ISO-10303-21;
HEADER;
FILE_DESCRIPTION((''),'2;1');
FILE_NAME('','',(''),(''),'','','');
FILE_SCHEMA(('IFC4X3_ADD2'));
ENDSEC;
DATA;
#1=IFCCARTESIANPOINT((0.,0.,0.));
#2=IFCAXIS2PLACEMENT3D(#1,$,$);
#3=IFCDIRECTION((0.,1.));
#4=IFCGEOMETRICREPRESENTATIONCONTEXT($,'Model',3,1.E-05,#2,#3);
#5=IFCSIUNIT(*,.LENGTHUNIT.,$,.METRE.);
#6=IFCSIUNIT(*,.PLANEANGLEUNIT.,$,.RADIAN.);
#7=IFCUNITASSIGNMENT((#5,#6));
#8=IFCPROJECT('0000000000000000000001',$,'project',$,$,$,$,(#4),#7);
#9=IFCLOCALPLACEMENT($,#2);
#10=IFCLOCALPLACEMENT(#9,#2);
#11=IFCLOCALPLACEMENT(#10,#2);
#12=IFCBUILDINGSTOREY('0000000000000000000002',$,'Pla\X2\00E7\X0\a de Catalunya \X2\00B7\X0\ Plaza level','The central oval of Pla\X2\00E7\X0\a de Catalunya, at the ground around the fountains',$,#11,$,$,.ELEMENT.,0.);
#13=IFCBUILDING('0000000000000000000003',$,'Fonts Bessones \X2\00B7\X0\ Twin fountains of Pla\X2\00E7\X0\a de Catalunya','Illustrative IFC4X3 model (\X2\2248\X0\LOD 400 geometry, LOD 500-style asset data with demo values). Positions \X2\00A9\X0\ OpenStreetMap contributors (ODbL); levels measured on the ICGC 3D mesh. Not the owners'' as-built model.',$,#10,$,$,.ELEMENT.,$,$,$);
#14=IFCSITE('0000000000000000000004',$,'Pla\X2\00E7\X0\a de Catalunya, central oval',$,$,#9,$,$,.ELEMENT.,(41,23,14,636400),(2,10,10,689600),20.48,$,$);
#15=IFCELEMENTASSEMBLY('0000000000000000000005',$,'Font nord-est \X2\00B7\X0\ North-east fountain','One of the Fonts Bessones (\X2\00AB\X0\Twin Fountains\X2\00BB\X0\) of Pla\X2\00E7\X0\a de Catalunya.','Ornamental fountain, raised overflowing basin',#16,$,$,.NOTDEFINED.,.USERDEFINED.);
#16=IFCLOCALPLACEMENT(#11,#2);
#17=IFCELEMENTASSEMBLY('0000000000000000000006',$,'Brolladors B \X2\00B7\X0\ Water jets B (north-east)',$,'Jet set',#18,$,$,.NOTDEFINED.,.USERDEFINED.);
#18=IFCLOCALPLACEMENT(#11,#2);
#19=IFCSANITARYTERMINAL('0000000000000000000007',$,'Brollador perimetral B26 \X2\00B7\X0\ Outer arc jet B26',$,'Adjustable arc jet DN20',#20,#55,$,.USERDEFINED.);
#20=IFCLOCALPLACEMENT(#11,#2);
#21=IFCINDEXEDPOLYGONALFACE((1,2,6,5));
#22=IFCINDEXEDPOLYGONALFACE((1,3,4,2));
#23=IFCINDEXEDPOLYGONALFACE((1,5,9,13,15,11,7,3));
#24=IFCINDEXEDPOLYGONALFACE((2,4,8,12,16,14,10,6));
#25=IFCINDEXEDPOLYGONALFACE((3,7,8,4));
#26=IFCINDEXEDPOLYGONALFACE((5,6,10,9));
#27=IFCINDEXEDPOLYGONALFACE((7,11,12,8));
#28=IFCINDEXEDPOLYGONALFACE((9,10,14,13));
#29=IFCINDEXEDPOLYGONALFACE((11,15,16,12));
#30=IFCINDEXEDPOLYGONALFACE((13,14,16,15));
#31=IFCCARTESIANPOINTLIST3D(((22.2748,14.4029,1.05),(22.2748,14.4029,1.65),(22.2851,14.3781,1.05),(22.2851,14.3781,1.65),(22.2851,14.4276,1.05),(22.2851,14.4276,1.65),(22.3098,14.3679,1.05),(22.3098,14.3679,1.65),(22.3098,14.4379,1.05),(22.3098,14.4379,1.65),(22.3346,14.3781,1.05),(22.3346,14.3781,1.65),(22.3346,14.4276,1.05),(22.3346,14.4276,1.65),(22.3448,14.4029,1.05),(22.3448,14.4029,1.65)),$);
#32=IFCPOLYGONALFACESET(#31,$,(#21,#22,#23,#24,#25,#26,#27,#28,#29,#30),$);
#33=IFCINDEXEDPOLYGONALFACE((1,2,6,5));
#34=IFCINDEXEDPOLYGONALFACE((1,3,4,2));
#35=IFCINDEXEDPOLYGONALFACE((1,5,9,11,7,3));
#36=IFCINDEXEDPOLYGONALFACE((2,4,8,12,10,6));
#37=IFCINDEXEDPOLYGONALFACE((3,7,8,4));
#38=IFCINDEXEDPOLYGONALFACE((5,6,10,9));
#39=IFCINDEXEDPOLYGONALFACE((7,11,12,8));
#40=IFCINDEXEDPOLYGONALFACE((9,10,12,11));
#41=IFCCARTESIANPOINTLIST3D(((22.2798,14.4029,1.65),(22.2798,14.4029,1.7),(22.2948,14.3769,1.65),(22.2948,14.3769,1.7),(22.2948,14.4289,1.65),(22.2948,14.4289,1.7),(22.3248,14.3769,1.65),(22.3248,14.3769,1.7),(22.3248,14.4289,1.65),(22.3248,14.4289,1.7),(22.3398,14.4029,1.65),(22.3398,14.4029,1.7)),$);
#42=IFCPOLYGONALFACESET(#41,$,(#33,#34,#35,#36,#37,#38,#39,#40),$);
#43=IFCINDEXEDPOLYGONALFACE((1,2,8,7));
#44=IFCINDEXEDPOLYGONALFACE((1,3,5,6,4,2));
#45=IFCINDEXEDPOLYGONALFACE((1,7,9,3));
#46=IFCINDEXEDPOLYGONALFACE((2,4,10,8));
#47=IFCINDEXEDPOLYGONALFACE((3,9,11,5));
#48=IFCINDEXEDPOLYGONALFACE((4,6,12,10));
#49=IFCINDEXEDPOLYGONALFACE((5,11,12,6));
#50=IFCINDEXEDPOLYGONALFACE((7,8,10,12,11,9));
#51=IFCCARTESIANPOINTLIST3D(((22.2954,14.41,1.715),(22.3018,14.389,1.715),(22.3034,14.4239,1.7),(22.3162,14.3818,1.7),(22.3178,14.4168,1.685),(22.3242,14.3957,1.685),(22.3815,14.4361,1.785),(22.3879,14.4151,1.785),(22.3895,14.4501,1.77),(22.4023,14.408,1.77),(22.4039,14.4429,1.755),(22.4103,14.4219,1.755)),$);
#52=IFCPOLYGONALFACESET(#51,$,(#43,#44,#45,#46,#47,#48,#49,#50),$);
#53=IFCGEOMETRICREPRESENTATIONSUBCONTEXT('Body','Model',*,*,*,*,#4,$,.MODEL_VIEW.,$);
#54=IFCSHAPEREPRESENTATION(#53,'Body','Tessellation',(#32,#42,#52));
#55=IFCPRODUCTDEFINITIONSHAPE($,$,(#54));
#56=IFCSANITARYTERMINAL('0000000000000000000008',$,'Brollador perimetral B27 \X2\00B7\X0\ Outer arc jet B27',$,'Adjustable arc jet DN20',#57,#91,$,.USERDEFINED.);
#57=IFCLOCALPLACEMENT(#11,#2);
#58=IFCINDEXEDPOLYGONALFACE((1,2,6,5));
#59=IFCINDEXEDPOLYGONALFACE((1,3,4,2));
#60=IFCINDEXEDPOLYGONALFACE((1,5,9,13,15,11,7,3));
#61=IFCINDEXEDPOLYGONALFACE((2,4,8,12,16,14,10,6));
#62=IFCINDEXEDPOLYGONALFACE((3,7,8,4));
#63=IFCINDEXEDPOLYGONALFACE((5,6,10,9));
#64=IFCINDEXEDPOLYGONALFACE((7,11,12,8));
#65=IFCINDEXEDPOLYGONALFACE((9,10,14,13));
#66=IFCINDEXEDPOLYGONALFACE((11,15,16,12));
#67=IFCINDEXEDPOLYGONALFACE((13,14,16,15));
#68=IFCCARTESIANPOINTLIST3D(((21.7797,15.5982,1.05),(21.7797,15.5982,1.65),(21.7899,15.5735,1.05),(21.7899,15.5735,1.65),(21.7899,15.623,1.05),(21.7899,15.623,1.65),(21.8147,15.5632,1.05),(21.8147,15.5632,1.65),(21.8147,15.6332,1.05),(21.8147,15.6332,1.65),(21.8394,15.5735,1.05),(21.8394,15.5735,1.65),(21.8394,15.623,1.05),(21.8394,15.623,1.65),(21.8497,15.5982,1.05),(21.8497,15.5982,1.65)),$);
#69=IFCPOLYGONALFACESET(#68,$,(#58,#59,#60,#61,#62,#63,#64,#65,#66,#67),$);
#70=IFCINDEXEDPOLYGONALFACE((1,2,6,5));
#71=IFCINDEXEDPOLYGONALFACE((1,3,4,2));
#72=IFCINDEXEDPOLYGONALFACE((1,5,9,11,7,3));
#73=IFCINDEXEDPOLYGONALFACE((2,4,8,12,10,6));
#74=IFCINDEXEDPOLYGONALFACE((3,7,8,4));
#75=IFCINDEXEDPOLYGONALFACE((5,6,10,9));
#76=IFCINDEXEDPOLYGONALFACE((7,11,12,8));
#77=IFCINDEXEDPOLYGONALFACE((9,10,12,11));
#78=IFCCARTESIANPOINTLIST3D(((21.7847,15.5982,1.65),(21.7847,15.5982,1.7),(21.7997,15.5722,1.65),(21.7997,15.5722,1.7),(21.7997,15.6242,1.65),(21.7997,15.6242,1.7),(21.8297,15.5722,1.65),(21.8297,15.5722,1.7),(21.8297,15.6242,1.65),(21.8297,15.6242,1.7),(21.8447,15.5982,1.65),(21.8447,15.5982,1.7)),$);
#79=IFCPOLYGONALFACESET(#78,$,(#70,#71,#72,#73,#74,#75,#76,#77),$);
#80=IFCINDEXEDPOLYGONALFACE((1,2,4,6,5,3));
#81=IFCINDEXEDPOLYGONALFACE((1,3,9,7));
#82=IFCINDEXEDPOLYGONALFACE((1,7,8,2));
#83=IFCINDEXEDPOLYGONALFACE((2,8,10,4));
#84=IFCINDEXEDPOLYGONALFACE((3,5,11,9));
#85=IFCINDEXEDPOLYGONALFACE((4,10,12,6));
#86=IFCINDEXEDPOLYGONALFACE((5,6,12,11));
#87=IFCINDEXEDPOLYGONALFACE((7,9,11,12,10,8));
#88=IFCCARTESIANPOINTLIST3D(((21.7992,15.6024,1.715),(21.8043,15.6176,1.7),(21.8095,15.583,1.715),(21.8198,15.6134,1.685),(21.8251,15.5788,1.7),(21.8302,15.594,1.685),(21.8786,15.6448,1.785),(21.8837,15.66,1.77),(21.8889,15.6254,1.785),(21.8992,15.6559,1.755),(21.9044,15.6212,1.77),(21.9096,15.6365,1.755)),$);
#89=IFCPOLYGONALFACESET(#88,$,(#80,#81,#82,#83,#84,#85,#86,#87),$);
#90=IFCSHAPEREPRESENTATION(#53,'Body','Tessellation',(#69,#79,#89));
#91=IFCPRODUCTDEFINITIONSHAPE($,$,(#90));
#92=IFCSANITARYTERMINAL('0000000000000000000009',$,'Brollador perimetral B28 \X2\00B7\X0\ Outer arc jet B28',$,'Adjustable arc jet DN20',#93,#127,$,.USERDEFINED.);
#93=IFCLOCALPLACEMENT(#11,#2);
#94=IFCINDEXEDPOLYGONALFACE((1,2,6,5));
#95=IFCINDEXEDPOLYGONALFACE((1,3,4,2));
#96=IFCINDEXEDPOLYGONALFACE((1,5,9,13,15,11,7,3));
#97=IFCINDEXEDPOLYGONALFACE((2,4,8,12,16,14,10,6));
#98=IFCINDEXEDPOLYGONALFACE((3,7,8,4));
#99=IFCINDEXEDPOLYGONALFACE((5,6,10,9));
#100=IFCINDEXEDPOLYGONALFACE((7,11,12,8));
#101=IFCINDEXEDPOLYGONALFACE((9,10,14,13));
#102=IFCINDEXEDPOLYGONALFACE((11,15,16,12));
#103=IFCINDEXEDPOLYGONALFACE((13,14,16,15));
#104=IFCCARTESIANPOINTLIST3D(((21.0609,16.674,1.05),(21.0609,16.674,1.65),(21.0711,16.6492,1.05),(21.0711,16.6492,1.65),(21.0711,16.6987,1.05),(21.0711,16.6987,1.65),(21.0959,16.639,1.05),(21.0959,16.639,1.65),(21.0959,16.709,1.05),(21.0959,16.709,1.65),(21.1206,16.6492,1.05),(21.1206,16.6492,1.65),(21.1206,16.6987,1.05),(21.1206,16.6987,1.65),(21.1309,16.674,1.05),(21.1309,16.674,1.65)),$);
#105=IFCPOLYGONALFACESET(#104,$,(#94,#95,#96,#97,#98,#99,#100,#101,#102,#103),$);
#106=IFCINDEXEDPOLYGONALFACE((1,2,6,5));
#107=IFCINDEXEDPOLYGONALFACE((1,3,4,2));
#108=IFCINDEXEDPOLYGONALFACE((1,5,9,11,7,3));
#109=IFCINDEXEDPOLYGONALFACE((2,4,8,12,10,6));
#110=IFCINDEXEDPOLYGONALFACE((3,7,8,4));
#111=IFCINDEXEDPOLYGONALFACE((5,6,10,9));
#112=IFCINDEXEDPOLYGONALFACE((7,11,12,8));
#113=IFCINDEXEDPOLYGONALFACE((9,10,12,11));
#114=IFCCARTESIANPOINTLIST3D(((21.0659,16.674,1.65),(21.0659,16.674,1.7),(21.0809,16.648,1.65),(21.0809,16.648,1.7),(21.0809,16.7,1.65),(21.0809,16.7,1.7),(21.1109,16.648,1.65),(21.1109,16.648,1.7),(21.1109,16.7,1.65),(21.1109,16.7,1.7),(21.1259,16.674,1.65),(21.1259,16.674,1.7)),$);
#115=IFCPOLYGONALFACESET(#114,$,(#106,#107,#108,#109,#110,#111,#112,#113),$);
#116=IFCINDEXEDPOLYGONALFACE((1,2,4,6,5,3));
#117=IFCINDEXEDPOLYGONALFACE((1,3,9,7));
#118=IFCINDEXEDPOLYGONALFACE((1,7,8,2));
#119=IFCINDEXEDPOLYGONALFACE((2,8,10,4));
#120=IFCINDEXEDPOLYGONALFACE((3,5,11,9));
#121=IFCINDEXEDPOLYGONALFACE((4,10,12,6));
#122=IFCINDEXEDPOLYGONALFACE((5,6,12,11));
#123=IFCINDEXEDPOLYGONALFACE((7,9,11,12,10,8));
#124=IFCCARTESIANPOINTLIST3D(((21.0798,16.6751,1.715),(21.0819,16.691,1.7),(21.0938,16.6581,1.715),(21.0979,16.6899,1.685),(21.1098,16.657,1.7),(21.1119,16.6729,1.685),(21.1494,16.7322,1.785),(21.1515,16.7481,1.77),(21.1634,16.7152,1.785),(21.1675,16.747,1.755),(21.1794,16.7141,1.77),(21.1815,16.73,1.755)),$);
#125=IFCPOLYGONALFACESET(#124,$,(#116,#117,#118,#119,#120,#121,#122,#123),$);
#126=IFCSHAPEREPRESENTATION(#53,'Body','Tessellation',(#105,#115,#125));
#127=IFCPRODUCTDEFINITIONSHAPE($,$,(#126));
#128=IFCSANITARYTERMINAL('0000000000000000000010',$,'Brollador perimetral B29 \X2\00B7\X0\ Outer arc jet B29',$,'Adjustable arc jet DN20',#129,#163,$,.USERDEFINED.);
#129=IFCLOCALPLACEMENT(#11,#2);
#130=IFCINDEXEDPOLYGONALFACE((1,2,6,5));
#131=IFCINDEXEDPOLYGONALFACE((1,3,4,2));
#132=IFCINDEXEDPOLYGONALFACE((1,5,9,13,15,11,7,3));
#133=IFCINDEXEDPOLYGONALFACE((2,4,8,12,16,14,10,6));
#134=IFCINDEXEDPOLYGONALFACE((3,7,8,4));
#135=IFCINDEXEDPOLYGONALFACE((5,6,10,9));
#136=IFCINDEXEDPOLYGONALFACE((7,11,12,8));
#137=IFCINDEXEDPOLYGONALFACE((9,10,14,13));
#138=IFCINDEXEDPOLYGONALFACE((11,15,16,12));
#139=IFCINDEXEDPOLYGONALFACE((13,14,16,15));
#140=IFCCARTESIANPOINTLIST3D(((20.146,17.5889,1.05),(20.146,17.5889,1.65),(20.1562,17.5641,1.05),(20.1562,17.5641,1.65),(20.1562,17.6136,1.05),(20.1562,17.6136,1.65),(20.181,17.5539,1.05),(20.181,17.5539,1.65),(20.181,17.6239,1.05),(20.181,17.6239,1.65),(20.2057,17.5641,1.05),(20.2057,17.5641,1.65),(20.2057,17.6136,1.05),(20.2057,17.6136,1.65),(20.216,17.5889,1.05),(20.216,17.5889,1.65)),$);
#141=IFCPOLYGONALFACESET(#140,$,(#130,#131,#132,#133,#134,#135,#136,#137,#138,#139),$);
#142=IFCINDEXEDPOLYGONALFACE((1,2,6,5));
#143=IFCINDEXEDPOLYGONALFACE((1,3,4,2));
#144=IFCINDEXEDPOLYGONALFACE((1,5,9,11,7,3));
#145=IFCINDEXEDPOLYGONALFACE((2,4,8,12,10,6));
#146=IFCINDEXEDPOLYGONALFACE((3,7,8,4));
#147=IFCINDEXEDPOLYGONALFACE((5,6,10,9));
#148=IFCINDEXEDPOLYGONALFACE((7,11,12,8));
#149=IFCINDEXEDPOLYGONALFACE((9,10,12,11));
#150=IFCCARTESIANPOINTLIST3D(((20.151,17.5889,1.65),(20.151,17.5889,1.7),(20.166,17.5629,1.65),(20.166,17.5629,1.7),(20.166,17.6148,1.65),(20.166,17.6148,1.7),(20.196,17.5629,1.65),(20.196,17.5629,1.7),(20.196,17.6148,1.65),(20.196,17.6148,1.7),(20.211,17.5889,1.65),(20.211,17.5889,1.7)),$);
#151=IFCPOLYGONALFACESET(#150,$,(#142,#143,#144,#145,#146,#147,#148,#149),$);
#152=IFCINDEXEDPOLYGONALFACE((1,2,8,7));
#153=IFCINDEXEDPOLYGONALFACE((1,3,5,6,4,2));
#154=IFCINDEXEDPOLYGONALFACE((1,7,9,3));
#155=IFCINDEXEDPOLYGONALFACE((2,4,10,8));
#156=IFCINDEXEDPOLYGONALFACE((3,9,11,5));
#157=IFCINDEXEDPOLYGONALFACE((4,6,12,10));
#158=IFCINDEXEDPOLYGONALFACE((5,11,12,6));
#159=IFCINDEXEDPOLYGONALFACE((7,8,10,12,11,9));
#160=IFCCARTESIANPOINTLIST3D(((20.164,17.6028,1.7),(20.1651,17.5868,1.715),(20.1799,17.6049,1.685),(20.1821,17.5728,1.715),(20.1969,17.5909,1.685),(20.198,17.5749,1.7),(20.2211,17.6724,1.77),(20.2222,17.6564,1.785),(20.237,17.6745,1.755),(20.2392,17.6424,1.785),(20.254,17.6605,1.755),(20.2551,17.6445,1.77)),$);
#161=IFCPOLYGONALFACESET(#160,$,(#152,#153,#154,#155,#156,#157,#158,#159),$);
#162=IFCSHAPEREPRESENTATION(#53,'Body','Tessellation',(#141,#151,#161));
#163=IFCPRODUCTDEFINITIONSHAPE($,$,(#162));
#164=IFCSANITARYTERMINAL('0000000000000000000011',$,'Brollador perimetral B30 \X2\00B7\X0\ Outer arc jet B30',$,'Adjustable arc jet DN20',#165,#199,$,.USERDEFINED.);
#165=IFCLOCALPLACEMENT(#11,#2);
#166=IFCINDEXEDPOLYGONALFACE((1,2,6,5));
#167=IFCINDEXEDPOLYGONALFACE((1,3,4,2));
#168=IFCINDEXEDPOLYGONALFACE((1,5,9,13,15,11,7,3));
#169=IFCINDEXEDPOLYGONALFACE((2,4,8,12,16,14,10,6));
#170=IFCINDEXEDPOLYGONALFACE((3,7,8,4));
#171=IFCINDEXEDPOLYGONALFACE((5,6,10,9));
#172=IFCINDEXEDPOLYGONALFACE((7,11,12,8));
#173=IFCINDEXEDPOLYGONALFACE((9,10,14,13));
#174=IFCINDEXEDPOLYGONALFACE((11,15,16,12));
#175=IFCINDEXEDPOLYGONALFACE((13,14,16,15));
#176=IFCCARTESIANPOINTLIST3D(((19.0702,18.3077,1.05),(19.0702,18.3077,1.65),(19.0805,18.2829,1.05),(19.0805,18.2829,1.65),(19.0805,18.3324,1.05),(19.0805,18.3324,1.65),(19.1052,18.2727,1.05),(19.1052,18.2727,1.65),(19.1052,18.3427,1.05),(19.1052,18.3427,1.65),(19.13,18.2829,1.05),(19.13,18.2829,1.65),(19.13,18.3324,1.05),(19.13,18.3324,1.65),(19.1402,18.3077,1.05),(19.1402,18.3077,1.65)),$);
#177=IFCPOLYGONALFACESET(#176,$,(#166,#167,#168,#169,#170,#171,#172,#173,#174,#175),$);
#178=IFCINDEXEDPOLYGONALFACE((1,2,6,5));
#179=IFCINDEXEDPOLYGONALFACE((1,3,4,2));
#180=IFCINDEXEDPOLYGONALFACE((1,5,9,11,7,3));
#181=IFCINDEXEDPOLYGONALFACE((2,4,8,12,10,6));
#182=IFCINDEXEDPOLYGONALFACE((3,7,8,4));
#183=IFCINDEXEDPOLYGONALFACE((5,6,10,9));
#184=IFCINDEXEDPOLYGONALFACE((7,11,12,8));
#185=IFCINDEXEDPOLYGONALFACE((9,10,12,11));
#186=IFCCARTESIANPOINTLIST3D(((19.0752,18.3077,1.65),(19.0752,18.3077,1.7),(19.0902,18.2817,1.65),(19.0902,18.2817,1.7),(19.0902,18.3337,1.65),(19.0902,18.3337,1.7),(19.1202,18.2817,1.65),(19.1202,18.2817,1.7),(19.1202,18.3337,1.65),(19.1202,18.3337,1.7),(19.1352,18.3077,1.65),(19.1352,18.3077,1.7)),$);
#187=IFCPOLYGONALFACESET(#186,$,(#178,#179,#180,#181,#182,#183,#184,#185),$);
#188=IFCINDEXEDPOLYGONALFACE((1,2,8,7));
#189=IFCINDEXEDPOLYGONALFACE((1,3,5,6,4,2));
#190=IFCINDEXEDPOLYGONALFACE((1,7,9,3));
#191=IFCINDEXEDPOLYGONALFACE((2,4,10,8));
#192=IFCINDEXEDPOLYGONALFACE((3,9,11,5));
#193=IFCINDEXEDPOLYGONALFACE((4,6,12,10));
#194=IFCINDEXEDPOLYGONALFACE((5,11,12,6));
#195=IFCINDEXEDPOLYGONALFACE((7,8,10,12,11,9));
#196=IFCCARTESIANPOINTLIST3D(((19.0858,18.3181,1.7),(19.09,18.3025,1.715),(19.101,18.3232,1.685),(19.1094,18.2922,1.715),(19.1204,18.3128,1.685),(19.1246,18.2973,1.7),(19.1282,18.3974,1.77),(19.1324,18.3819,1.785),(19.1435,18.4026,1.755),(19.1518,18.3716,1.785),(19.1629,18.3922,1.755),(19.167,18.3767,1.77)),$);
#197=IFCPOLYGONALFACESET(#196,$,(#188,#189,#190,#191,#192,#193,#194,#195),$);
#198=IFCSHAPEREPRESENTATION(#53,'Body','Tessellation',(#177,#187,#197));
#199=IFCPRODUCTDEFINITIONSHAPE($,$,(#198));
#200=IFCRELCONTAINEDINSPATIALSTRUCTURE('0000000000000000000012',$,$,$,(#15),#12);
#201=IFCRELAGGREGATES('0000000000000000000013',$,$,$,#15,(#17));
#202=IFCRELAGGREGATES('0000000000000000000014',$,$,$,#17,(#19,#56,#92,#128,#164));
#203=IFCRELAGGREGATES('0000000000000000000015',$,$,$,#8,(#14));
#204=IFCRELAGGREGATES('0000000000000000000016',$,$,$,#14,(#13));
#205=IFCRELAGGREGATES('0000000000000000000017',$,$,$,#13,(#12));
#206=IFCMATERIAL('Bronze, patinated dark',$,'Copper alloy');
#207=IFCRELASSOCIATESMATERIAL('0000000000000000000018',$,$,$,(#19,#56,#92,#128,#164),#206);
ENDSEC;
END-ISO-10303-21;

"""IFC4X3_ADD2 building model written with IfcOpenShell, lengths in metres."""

from ifc_helpers import new_model, si_unit, direction, frame, origin, place, context, subcontext, project, spatial, polyline, outline, extrude, material, element, aggregate, save


model = new_model("IFC4X3_ADD2")

# Units and contexts
model_context = context("Model", 3, precision=1e-05, world=origin(), true_north=direction((0.0, 1.0)))
body_context = subcontext(model_context, "Body", "Model", "MODEL_VIEW")
ifc_project = project(units=[si_unit("LENGTHUNIT", "METRE"), si_unit("PLANEANGLEUNIT", "RADIAN")], contexts=[model_context])

# Site, building, storey
site_placement = place(None, origin())
site = spatial("IfcSite", under=ifc_project, at=site_placement, Name="Plaça de Catalunya, central oval", CompositionType="ELEMENT", RefLatitude=(41, 23, 14, 636400), RefLongitude=(2, 10, 10, 689600), RefElevation=20.48)
building_placement = place(site_placement, origin())
building = spatial("IfcBuilding", under=site, at=building_placement, Name="Fonts Bessones · Twin fountains of Plaça de Catalunya", Description="Illustrative IFC4X3 model (≈LOD 400 geometry, LOD 500-style asset data with demo values). Positions © OpenStreetMap contributors (ODbL); levels measured on the ICGC 3D mesh. Not the owners' as-built model.", CompositionType="ELEMENT")
storey_placement = place(building_placement, origin())
storey = spatial("IfcBuildingStorey", under=building, at=storey_placement, Name="Plaça de Catalunya · Plaza level", Description="The central oval of Plaça de Catalunya, at the ground around the fountains", CompositionType="ELEMENT", Elevation=0.0)

# Element assemblies, sanitary terminals
assembly_1_placement = place(building_placement, origin())
assembly_1 = element("IfcElementAssembly", 1, at=assembly_1_placement, inside=storey, Name="Font nord-est · North-east fountain", Description="One of the Fonts Bessones («Twin Fountains») of Plaça de Catalunya.", ObjectType="Ornamental fountain, raised overflowing basin", AssemblyPlace="NOTDEFINED", PredefinedType="USERDEFINED")
assembly_2_placement = place(building_placement, origin())
assembly_2 = element("IfcElementAssembly", 2, at=assembly_2_placement, Name="Brolladors B · Water jets B (north-east)", ObjectType="Jet set", AssemblyPlace="NOTDEFINED", PredefinedType="USERDEFINED")
aggregate(assembly_1, [assembly_2])
ifc_material_1 = material(Name="Bronze, patinated dark", Category="Copper alloy")
sanitary_terminal_1_placement = place(building_placement, origin())
sanitary_terminal_1 = element("IfcSanitaryTerminal", 3, at=sanitary_terminal_1_placement, material=ifc_material_1, Name="Brollador perimetral B26 · Outer arc jet B26", ObjectType="Adjustable arc jet DN20", PredefinedType="USERDEFINED", context=body_context, shape_type="SweptSolid", body=[
    extrude(outline(polyline([(22.3448, 14.4029), (22.3346, 14.4276), (22.3098, 14.4379), (22.2851, 14.4276), (22.2748, 14.4029), (22.2851, 14.3781), (22.3098, 14.3679), (22.3346, 14.3781), (22.3448, 14.4029)])), frame((0.0, 0.0, 1.05)), (0.0, 0.0, 1.0), 0.6),
    extrude(outline(polyline([(22.3398, 14.4029), (22.3248, 14.4289), (22.2948, 14.4289), (22.2798, 14.4029), (22.2948, 14.3769), (22.3248, 14.3769), (22.3398, 14.4029)])), frame((0.0, 0.0, 1.65)), (0.0, 0.0, 1.0), 0.05),
    extrude(outline(polyline([(0.022, 0.0), (0.011, 0.0191), (-0.011, 0.0191), (-0.022, 0.0), (-0.011, -0.0191), (0.011, -0.0191), (0.022, 0.0)])), frame((22.3098, 14.4029, 1.7), z_axis=(0.755363, 0.229137, 0.613941), x_axis=(0.290285, -0.95694, 0.0)), (0.0, 0.0, 1.0), 0.114),
])
sanitary_terminal_2_placement = place(building_placement, origin())
sanitary_terminal_2 = element("IfcSanitaryTerminal", 4, at=sanitary_terminal_2_placement, material=ifc_material_1, Name="Brollador perimetral B27 · Outer arc jet B27", ObjectType="Adjustable arc jet DN20", PredefinedType="USERDEFINED", context=body_context, shape_type="SweptSolid", body=[
    extrude(outline(polyline([(21.8497, 15.5982), (21.8394, 15.623), (21.8147, 15.6332), (21.7899, 15.623), (21.7797, 15.5982), (21.7899, 15.5735), (21.8147, 15.5632), (21.8394, 15.5735), (21.8497, 15.5982)])), frame((0.0, 0.0, 1.05)), (0.0, 0.0, 1.0), 0.6),
    extrude(outline(polyline([(21.8447, 15.5982), (21.8297, 15.6242), (21.7997, 15.6242), (21.7847, 15.5982), (21.7997, 15.5722), (21.8297, 15.5722), (21.8447, 15.5982)])), frame((0.0, 0.0, 1.65)), (0.0, 0.0, 1.0), 0.05),
    extrude(outline(polyline([(0.022, 0.0), (0.011, 0.0191), (-0.011, 0.0191), (-0.022, 0.0), (-0.011, -0.0191), (0.011, -0.0191), (0.022, 0.0)])), frame((21.8147, 15.5982, 1.7), z_axis=(0.696147, 0.372098, 0.613941), x_axis=(0.471397, -0.881921, 0.0)), (0.0, 0.0, 1.0), 0.114),
])
sanitary_terminal_3_placement = place(building_placement, origin())
sanitary_terminal_3 = element("IfcSanitaryTerminal", 5, at=sanitary_terminal_3_placement, material=ifc_material_1, Name="Brollador perimetral B28 · Outer arc jet B28", ObjectType="Adjustable arc jet DN20", PredefinedType="USERDEFINED", context=body_context, shape_type="SweptSolid", body=[
    extrude(outline(polyline([(21.1309, 16.674), (21.1206, 16.6987), (21.0959, 16.709), (21.0711, 16.6987), (21.0609, 16.674), (21.0711, 16.6492), (21.0959, 16.639), (21.1206, 16.6492), (21.1309, 16.674)])), frame((0.0, 0.0, 1.05)), (0.0, 0.0, 1.0), 0.6),
    extrude(outline(polyline([(21.1259, 16.674), (21.1109, 16.7), (21.0809, 16.7), (21.0659, 16.674), (21.0809, 16.648), (21.1109, 16.648), (21.1259, 16.674)])), frame((0.0, 0.0, 1.65)), (0.0, 0.0, 1.0), 0.05),
    extrude(outline(polyline([(0.022, 0.0), (0.011, 0.0191), (-0.011, 0.0191), (-0.022, 0.0), (-0.011, -0.0191), (0.011, -0.0191), (0.022, 0.0)])), frame((21.0959, 16.674, 1.7), z_axis=(0.610178, 0.50076, 0.613941), x_axis=(0.634393, -0.77301, 0.0)), (0.0, 0.0, 1.0), 0.114),
])
sanitary_terminal_4_placement = place(building_placement, origin())
sanitary_terminal_4 = element("IfcSanitaryTerminal", 6, at=sanitary_terminal_4_placement, material=ifc_material_1, Name="Brollador perimetral B29 · Outer arc jet B29", ObjectType="Adjustable arc jet DN20", PredefinedType="USERDEFINED", context=body_context, shape_type="SweptSolid", body=[
    extrude(outline(polyline([(20.216, 17.5889), (20.2057, 17.6136), (20.181, 17.6239), (20.1562, 17.6136), (20.146, 17.5889), (20.1562, 17.5641), (20.181, 17.5539), (20.2057, 17.5641), (20.216, 17.5889)])), frame((0.0, 0.0, 1.05)), (0.0, 0.0, 1.0), 0.6),
    extrude(outline(polyline([(20.211, 17.5889), (20.196, 17.6148), (20.166, 17.6148), (20.151, 17.5889), (20.166, 17.5629), (20.196, 17.5629), (20.211, 17.5889)])), frame((0.0, 0.0, 1.65)), (0.0, 0.0, 1.0), 0.05),
    extrude(outline(polyline([(0.022, 0.0), (0.011, 0.0191), (-0.011, 0.0191), (-0.022, 0.0), (-0.011, -0.0191), (0.011, -0.0191), (0.022, 0.0)])), frame((20.181, 17.5889, 1.7), z_axis=(0.50076, 0.610178, 0.613941), x_axis=(0.77301, -0.634393, 0.0)), (0.0, 0.0, 1.0), 0.114),
])
sanitary_terminal_5_placement = place(building_placement, origin())
sanitary_terminal_5 = element("IfcSanitaryTerminal", 7, at=sanitary_terminal_5_placement, material=ifc_material_1, Name="Brollador perimetral B30 · Outer arc jet B30", ObjectType="Adjustable arc jet DN20", PredefinedType="USERDEFINED", context=body_context, shape_type="SweptSolid", body=[
    extrude(outline(polyline([(19.1402, 18.3077), (19.13, 18.3324), (19.1052, 18.3427), (19.0805, 18.3324), (19.0702, 18.3077), (19.0805, 18.2829), (19.1052, 18.2727), (19.13, 18.2829), (19.1402, 18.3077)])), frame((0.0, 0.0, 1.05)), (0.0, 0.0, 1.0), 0.6),
    extrude(outline(polyline([(19.1352, 18.3077), (19.1202, 18.3337), (19.0902, 18.3337), (19.0752, 18.3077), (19.0902, 18.2817), (19.1202, 18.2817), (19.1352, 18.3077)])), frame((0.0, 0.0, 1.65)), (0.0, 0.0, 1.0), 0.05),
    extrude(outline(polyline([(0.022, 0.0), (0.011, 0.0191), (-0.011, 0.0191), (-0.022, 0.0), (-0.011, -0.0191), (0.011, -0.0191), (0.022, 0.0)])), frame((19.1052, 18.3077, 1.7), z_axis=(0.372098, 0.696147, 0.613941), x_axis=(0.881921, -0.471397, 0.0)), (0.0, 0.0, 1.0), 0.114),
])
aggregate(assembly_2, [sanitary_terminal_1, sanitary_terminal_2, sanitary_terminal_3, sanitary_terminal_4, sanitary_terminal_5])

save(model, "model.ifc")
